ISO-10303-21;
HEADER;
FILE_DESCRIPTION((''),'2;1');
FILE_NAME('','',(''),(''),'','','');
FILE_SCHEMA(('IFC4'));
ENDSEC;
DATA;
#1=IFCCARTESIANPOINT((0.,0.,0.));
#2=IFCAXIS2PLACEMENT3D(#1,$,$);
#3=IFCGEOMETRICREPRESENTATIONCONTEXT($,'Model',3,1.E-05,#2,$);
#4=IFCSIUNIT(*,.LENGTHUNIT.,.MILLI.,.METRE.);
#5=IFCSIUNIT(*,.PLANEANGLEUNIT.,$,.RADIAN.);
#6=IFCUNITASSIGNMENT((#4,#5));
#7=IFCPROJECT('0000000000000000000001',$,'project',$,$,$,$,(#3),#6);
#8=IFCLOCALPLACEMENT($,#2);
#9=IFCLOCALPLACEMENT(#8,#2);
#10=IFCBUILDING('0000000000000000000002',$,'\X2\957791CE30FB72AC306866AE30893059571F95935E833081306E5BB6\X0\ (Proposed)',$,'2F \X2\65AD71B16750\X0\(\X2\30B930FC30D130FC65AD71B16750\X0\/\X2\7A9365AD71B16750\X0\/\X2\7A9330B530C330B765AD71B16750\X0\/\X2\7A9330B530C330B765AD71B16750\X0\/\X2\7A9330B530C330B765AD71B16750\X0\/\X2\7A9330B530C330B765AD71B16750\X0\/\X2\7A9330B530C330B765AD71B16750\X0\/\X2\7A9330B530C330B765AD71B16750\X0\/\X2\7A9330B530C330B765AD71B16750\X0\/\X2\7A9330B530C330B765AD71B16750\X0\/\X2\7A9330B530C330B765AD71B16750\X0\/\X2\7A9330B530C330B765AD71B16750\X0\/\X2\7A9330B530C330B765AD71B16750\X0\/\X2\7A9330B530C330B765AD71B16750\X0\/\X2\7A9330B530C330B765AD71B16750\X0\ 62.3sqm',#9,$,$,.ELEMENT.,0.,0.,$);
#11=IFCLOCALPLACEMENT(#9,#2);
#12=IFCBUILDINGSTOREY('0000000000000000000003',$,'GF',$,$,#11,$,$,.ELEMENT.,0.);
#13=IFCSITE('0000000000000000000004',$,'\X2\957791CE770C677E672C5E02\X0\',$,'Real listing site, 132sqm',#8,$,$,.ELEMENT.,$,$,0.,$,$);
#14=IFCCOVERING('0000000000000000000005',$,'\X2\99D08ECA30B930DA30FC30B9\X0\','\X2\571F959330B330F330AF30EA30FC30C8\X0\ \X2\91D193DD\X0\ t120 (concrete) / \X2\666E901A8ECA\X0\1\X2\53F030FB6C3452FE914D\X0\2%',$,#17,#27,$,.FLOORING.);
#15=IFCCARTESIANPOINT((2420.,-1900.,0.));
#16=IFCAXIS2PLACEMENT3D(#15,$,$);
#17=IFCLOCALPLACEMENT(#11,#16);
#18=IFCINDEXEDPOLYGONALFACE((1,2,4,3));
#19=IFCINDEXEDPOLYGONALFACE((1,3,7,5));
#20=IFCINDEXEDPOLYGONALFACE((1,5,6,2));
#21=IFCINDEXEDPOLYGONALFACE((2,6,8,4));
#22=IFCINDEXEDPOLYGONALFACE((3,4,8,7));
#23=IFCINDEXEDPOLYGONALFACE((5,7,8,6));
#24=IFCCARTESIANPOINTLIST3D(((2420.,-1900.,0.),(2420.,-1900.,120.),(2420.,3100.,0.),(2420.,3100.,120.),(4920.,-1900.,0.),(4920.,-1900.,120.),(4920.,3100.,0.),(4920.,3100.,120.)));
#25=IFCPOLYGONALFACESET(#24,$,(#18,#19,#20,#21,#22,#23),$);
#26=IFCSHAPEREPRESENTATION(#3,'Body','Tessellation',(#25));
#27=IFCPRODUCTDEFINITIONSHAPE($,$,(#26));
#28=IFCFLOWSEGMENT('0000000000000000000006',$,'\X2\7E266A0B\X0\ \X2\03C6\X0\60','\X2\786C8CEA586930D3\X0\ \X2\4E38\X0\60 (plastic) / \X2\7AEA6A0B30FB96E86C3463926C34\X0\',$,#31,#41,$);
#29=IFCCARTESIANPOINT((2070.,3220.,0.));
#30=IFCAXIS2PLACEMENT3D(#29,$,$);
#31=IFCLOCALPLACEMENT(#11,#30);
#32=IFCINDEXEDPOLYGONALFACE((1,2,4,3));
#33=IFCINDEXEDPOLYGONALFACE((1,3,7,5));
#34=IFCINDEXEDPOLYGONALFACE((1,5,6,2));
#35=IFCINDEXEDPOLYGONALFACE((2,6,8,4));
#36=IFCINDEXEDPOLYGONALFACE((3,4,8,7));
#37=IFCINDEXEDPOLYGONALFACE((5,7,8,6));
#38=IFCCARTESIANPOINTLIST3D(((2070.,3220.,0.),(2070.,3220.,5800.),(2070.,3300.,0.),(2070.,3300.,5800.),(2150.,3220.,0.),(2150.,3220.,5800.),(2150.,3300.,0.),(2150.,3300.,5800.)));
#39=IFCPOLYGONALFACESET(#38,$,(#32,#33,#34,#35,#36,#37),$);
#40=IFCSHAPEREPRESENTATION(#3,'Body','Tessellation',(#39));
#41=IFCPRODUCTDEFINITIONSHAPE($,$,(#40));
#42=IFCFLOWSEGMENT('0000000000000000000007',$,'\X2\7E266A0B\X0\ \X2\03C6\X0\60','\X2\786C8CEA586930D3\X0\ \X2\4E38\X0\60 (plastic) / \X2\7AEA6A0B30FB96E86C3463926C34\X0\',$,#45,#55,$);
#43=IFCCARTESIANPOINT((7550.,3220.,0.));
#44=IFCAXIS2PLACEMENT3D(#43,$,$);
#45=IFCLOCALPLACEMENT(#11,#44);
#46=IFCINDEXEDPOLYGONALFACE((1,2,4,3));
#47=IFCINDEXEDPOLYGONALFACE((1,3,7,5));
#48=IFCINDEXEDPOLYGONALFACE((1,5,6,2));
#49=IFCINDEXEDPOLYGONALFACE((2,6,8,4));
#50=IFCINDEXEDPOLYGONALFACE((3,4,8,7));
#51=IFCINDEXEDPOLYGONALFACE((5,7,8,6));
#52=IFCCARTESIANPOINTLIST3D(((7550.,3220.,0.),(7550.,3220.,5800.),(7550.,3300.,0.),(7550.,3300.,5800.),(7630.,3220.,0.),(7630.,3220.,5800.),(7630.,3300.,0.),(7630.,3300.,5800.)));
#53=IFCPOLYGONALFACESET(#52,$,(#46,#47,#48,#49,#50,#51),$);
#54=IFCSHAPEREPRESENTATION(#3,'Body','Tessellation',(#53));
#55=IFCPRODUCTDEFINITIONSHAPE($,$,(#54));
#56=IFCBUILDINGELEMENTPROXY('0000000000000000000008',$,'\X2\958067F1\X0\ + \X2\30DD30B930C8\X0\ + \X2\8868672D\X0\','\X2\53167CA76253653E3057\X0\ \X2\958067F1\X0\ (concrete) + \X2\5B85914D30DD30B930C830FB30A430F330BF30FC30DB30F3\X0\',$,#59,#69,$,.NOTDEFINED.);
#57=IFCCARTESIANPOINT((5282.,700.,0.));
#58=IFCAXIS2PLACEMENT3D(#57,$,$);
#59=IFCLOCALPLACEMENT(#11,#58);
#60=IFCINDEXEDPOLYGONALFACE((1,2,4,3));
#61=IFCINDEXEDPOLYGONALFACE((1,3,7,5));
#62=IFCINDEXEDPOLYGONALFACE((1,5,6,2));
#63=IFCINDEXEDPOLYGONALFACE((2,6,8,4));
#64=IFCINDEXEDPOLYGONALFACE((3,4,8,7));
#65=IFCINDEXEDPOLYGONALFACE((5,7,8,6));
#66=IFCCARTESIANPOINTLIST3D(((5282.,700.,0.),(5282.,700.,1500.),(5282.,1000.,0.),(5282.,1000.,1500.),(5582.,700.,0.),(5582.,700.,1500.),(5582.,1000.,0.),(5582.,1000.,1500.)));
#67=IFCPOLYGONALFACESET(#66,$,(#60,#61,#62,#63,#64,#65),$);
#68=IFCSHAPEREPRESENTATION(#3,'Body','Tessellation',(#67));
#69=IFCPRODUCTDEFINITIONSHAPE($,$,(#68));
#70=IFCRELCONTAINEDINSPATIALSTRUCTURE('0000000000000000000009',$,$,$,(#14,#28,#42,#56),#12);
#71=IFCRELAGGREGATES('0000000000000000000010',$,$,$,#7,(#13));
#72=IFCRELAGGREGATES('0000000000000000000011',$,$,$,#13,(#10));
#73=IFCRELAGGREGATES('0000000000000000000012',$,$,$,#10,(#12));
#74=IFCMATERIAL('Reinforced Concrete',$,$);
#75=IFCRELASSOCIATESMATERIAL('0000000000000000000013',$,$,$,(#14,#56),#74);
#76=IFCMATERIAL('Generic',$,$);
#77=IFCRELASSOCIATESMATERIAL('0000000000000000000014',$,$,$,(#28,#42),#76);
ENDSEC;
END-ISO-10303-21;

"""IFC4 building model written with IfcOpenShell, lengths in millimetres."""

from ifc_helpers import new_model, si_unit, frame, frame_2d, origin, place, context, project, spatial, rectangle, extrude, material, element, save


model = new_model("IFC4")

# Units and contexts
model_context = context("Model", 3, precision=1e-05, world=origin())
ifc_project = project(units=[si_unit("LENGTHUNIT", "METRE", prefix="MILLI"), si_unit("PLANEANGLEUNIT", "RADIAN")], contexts=[model_context])

# Site, building, storey
site_placement = place(None, origin())
site = spatial("IfcSite", under=ifc_project, at=site_placement, Name="長野県松本市", ObjectType="Real listing site, 132sqm", CompositionType="ELEMENT", RefElevation=0.0)
building_placement = place(site_placement, origin())
building = spatial("IfcBuilding", under=site, at=building_placement, Name="長野・犬と暮らす土間広めの家 (Proposed)", ObjectType="2F 断熱材(スーパー断熱材/窓断熱材/窓サッシ断熱材/窓サッシ断熱材/窓サッシ断熱材/窓サッシ断熱材/窓サッシ断熱材/窓サッシ断熱材/窓サッシ断熱材/窓サッシ断熱材/窓サッシ断熱材/窓サッシ断熱材/窓サッシ断熱材/窓サッシ断熱材/窓サッシ断熱材 62.3sqm", CompositionType="ELEMENT", ElevationOfRefHeight=0.0, ElevationOfTerrain=0.0)
storey_placement = place(building_placement, origin())
storey = spatial("IfcBuildingStorey", under=building, at=storey_placement, Name="GF", CompositionType="ELEMENT", Elevation=0.0)

# Shared definitions
ifc_material_1 = material(Name="Reinforced Concrete")

# Covering
covering_1_placement = place(storey_placement, frame((2420.0, -1900.0, 0.0)))
element("IfcCovering", 1, at=covering_1_placement, inside=storey, material=ifc_material_1, Name="駐車スペース", Description="土間コンクリート 金鏝 t120 (concrete) / 普通車1台・水勾配2%", PredefinedType="FLOORING", context=model_context, shape_type="SweptSolid", body=[
    extrude(rectangle(XDim=2500.0, YDim=5000.0, at=frame_2d((1250.0, 2500.0))), frame((2420.0, -1900.0, 0.0)), (0.0, 0.0, 1.0), 120.0),
])

# Flow segments
ifc_material_2 = material(Name="Generic")
flow_segment_1_placement = place(storey_placement, frame((2070.0, 3220.0, 0.0)))
element("IfcFlowSegment", 2, at=flow_segment_1_placement, inside=storey, material=ifc_material_2, Name="縦樋 φ60", Description="硬質塩ビ 丸60 (plastic) / 竪樋・雨水排水", context=model_context, shape_type="SweptSolid", body=[
    extrude(rectangle(XDim=80.0, YDim=80.0, at=frame_2d((40.0, 40.0))), frame((2070.0, 3220.0, 0.0)), (0.0, 0.0, 1.0), 5800.0),
])
flow_segment_2_placement = place(storey_placement, frame((7550.0, 3220.0, 0.0)))
element("IfcFlowSegment", 3, at=flow_segment_2_placement, inside=storey, material=ifc_material_2, Name="縦樋 φ60", Description="硬質塩ビ 丸60 (plastic) / 竪樋・雨水排水", context=model_context, shape_type="SweptSolid", body=[
    extrude(rectangle(XDim=80.0, YDim=80.0, at=frame_2d((40.0, 40.0))), frame((7550.0, 3220.0, 0.0)), (0.0, 0.0, 1.0), 5800.0),
])

# Building element proxy
proxy_placement = place(storey_placement, frame((5282.0, 700.0, 0.0)))
element("IfcBuildingElementProxy", 4, at=proxy_placement, inside=storey, material=ifc_material_1, Name="門柱 + ポスト + 表札", Description="化粧打放し 門柱 (concrete) + 宅配ポスト・インターホン", PredefinedType="NOTDEFINED", context=model_context, shape_type="SweptSolid", body=[
    extrude(rectangle(XDim=300.0, YDim=300.0, at=frame_2d((150.0, 150.0))), frame((5282.0, 700.0, 0.0)), (0.0, 0.0, 1.0), 1500.0),
])

save(model, "model.ifc")
